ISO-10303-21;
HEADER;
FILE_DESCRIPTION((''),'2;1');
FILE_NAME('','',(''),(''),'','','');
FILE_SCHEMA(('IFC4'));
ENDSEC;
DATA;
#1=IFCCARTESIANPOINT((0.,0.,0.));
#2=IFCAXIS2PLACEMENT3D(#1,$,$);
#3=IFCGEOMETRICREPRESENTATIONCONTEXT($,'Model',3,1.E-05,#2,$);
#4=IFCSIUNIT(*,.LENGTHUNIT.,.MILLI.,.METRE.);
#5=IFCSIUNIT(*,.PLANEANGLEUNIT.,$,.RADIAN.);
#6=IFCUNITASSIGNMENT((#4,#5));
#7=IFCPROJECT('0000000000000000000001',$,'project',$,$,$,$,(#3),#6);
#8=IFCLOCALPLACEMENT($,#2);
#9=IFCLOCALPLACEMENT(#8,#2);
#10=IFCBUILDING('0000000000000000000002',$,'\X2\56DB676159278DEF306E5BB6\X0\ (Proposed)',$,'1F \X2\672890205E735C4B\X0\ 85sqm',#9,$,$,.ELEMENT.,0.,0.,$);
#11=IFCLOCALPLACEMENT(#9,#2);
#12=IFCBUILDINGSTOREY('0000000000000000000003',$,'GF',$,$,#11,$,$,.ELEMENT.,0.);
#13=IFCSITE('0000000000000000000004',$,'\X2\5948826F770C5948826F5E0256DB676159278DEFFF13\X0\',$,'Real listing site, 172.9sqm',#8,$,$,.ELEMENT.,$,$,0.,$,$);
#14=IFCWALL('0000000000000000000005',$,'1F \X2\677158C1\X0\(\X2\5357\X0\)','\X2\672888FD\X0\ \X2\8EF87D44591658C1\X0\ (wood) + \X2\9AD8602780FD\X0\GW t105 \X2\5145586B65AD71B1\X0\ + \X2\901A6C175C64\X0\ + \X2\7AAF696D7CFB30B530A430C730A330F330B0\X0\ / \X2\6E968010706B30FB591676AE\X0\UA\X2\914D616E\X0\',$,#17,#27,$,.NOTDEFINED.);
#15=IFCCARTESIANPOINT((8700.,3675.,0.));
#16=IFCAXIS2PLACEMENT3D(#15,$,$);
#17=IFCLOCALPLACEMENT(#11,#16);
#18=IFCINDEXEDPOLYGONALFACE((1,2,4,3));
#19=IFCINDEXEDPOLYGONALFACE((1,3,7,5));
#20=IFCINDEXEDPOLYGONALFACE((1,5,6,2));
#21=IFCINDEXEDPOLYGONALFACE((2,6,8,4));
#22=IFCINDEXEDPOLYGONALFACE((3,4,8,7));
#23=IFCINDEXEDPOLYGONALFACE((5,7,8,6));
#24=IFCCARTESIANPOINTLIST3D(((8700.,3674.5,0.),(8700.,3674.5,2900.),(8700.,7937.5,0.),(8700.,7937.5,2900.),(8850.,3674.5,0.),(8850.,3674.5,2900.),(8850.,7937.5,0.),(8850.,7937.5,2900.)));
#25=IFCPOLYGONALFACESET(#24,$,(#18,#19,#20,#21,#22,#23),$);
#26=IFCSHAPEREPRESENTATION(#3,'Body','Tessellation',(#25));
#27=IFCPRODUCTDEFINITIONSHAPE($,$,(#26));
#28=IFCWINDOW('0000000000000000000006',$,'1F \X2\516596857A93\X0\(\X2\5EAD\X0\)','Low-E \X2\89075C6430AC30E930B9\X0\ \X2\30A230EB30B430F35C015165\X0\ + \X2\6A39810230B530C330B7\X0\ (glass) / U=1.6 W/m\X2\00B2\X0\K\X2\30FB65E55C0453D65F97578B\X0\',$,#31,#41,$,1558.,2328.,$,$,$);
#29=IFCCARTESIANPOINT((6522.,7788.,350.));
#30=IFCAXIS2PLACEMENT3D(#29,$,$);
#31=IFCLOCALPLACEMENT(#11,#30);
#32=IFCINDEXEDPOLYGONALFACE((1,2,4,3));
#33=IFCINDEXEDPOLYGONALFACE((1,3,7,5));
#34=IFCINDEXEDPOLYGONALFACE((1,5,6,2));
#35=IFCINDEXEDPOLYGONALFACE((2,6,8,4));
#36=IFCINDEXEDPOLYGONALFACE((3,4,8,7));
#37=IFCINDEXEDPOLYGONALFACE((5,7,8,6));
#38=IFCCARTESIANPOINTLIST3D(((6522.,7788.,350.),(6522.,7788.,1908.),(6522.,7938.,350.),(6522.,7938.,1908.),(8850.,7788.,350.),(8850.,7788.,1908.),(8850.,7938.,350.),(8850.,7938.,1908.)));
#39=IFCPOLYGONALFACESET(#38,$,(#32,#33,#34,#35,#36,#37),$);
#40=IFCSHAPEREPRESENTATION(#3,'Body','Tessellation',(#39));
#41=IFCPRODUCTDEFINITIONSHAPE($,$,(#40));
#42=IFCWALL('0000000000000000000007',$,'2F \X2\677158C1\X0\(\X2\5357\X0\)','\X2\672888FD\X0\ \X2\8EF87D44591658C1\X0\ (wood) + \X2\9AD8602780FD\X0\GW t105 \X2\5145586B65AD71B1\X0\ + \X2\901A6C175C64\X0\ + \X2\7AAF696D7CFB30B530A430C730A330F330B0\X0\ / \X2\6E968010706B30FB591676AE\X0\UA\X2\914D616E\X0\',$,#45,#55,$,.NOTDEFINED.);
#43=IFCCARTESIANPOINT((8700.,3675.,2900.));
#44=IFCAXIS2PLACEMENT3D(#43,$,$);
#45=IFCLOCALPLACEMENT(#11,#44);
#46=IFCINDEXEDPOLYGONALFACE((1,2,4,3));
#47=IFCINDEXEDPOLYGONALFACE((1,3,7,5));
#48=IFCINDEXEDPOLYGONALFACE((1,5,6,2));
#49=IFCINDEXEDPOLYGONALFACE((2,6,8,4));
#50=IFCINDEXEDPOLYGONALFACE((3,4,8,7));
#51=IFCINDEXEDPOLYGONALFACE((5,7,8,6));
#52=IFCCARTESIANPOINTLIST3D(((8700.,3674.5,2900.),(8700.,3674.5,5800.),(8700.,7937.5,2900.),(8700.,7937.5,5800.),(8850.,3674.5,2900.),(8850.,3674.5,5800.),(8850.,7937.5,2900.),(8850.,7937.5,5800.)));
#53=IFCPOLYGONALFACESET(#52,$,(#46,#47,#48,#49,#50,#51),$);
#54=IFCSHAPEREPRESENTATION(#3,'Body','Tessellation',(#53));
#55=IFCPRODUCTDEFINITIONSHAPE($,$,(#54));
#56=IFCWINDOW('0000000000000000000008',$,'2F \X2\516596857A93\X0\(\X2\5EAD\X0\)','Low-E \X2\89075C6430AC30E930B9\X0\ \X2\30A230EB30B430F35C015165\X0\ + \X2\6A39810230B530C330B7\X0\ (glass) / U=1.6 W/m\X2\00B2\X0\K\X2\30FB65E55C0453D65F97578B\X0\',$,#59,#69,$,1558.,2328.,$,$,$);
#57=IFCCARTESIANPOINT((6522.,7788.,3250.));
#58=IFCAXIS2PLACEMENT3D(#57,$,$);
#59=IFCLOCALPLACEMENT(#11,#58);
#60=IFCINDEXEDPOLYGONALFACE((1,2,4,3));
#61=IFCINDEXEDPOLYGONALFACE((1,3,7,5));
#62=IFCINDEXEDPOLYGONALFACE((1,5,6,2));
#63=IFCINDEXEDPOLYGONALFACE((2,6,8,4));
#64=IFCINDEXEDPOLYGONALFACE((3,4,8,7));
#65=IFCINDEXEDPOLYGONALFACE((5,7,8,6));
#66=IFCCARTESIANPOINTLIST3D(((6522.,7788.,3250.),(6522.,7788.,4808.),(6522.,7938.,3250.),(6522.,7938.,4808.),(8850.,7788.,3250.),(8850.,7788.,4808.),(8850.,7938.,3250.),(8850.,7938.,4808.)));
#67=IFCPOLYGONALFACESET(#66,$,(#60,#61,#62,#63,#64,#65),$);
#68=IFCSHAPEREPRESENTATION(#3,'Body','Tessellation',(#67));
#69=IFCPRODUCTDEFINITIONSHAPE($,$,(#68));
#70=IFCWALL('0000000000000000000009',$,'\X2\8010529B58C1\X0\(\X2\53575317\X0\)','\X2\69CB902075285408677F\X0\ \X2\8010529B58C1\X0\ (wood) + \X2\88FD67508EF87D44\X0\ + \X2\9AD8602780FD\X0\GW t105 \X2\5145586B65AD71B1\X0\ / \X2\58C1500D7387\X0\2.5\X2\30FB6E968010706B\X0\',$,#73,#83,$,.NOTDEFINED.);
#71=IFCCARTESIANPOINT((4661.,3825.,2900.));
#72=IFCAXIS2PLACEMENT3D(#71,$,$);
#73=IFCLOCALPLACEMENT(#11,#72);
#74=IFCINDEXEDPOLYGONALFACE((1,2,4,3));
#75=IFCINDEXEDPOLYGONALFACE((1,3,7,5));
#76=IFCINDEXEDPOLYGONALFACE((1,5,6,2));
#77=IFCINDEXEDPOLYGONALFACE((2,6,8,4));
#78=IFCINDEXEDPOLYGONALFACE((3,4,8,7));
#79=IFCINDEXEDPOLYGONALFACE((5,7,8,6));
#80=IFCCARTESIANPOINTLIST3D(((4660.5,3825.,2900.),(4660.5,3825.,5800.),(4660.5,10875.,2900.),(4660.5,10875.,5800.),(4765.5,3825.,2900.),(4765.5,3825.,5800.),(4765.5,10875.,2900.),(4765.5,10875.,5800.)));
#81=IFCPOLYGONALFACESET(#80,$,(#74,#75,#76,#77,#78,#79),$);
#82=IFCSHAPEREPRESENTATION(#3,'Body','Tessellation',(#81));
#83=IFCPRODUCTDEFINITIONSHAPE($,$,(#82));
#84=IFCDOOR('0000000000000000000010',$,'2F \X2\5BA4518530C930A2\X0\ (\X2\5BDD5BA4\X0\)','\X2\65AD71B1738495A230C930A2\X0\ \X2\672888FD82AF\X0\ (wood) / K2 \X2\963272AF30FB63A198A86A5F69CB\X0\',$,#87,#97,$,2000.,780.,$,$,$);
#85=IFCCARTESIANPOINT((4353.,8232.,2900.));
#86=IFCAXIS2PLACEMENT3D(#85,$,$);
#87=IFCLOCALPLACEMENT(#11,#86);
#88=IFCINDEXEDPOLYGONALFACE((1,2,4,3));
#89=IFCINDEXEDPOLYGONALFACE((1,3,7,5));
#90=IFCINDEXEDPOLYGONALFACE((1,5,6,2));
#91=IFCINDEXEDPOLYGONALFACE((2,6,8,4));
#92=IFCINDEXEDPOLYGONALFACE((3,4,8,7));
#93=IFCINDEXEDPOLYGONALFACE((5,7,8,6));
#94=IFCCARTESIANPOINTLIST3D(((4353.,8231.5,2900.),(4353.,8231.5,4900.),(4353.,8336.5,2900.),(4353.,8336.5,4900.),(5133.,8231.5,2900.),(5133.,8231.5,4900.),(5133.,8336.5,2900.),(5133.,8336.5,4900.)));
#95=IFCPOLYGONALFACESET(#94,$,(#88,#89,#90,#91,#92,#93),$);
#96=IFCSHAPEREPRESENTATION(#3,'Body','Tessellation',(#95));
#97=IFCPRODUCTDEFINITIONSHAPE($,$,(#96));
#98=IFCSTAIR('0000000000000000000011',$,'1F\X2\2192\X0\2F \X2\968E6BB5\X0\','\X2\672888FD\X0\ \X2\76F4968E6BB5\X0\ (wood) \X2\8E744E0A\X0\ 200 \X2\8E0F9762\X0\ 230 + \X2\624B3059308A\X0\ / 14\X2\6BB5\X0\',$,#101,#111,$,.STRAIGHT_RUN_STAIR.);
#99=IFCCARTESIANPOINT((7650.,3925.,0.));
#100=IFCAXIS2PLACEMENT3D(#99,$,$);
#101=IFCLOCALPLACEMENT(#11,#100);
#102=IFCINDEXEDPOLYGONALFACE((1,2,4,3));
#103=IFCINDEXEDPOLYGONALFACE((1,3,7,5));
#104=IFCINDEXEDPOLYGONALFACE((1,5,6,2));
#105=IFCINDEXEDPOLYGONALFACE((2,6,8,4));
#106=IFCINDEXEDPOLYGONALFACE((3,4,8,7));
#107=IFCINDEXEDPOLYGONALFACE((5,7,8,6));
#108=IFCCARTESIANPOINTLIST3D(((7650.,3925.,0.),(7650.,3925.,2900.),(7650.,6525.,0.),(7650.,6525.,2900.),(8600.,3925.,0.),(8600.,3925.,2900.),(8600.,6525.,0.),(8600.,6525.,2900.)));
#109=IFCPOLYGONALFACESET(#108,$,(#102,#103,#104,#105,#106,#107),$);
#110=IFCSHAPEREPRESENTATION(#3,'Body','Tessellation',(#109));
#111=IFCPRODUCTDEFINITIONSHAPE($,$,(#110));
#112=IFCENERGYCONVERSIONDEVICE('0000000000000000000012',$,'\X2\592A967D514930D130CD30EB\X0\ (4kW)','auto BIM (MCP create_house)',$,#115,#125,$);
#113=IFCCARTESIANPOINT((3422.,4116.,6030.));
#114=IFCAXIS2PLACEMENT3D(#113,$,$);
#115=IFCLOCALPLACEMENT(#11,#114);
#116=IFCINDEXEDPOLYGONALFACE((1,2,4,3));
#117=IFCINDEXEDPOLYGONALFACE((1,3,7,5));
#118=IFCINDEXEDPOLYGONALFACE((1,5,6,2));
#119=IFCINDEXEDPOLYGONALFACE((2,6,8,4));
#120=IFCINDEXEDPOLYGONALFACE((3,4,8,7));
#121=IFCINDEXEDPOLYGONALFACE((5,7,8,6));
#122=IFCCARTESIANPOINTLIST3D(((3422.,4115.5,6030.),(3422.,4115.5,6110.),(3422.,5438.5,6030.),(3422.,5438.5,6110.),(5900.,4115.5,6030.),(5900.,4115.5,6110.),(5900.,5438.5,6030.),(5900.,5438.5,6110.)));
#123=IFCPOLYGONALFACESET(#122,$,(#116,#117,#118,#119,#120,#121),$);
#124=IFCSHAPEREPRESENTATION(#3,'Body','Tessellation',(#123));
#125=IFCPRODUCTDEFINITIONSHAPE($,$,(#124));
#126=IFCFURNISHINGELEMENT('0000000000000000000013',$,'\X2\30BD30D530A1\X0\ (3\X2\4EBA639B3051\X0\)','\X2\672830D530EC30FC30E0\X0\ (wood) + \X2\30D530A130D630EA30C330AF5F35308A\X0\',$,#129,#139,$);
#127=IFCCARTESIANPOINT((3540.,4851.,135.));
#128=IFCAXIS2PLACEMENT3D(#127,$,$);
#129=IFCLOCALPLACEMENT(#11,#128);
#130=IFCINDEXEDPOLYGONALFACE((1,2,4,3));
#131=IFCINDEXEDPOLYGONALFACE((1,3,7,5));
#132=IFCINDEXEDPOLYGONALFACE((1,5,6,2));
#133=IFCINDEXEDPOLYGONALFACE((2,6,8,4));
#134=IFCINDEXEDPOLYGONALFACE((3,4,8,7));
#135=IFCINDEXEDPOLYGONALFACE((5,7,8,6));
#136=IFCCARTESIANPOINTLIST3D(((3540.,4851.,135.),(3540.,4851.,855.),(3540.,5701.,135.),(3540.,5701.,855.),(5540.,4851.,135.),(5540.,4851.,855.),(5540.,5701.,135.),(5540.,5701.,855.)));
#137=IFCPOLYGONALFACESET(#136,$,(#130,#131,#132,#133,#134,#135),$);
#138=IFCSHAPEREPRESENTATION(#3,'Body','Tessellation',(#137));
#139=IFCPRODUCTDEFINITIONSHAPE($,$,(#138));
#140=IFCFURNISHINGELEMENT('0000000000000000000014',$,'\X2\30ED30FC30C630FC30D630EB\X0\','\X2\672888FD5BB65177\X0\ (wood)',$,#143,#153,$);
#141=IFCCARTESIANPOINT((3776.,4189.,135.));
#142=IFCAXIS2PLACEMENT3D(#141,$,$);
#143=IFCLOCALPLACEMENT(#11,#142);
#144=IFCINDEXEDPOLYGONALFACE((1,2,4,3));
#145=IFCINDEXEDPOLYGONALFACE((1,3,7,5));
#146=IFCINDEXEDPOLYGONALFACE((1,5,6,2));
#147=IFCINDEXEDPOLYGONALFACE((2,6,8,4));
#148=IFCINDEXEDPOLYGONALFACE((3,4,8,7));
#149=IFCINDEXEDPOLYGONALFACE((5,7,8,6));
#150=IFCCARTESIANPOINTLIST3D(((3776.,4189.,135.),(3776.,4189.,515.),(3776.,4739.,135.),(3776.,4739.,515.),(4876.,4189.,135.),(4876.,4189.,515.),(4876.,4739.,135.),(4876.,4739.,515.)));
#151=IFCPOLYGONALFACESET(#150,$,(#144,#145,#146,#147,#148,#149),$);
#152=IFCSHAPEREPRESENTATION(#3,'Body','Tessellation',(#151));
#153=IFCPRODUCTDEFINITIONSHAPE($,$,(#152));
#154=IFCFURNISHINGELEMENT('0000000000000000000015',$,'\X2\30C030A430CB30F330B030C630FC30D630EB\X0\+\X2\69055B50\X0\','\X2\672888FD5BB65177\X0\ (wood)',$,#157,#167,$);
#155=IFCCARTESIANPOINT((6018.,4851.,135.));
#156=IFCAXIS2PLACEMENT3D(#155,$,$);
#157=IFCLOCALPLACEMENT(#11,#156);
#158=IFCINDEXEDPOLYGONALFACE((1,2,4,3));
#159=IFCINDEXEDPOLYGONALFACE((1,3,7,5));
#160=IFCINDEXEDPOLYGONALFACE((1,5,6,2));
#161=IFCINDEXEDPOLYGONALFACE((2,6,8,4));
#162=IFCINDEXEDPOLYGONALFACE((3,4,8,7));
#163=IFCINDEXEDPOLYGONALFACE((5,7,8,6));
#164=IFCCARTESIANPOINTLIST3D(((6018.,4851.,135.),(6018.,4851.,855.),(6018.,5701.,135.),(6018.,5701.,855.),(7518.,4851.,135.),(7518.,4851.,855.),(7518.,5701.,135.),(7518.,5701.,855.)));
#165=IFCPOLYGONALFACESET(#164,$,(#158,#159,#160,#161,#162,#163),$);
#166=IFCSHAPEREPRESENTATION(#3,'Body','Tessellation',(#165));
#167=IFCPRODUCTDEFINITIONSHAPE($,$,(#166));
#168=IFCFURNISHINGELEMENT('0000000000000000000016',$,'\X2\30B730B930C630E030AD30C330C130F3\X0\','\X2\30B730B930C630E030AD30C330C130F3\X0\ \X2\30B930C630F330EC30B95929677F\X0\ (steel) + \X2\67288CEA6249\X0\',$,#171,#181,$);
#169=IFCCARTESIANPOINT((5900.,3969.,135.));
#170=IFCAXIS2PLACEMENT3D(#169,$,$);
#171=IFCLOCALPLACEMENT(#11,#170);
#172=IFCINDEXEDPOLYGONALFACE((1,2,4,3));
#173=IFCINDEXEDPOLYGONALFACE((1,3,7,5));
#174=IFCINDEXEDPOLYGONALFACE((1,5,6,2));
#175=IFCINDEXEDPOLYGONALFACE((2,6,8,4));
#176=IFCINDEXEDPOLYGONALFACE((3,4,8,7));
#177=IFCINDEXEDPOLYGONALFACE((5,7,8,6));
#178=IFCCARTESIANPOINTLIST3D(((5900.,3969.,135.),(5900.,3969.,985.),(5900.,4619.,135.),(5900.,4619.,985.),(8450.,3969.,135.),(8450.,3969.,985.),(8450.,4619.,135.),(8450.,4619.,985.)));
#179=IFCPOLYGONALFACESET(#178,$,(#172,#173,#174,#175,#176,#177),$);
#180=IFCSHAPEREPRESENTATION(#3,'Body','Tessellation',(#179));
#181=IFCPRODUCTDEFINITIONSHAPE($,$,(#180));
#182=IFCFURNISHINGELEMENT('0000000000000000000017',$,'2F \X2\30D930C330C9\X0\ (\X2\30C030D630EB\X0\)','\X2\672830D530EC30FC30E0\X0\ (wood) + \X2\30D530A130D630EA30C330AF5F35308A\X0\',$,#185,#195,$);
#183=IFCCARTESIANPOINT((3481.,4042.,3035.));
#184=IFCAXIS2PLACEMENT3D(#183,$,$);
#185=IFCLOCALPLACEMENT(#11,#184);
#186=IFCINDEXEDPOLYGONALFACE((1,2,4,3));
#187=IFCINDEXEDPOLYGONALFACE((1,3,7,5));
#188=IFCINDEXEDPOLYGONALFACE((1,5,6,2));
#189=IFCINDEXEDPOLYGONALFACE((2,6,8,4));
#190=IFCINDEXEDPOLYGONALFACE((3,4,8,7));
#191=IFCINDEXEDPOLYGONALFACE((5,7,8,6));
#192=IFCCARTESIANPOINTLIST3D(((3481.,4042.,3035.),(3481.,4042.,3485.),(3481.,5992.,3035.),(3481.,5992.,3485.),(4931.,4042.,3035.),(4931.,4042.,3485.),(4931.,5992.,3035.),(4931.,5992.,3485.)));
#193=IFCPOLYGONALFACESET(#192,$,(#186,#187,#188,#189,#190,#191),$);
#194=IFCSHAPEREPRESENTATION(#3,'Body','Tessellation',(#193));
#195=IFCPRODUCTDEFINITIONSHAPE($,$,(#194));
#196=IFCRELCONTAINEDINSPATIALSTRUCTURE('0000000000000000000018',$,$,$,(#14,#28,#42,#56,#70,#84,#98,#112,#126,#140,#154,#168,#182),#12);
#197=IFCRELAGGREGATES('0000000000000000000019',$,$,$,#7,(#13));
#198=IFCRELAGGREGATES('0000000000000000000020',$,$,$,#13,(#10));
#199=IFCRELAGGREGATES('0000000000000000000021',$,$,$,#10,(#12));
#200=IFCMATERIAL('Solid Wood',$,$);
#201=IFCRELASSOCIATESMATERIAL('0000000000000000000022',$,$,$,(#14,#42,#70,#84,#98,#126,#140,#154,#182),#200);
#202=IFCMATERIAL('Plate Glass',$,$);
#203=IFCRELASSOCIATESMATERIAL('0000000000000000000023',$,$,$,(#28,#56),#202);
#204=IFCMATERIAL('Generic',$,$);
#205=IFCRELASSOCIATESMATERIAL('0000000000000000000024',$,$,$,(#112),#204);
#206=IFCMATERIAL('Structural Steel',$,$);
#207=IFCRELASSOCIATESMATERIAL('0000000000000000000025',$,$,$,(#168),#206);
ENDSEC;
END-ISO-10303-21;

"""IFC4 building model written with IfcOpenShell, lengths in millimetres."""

from ifc_helpers import new_model, si_unit, frame, frame_2d, origin, place, context, project, spatial, rectangle, extrude, material, element, fill, save


model = new_model("IFC4")

# Units and contexts
model_context = context("Model", 3, precision=1e-05, world=origin())
ifc_project = project(units=[si_unit("LENGTHUNIT", "METRE", prefix="MILLI"), si_unit("PLANEANGLEUNIT", "RADIAN")], contexts=[model_context])

# Site, building, storey
site_placement = place(None, origin())
site = spatial("IfcSite", under=ifc_project, at=site_placement, Name="奈良県奈良市四条大路３", ObjectType="Real listing site, 172.9sqm", CompositionType="ELEMENT", RefElevation=0.0)
building_placement = place(site_placement, origin())
building = spatial("IfcBuilding", under=site, at=building_placement, Name="四条大路の家 (Proposed)", ObjectType="1F 木造平屋 85sqm", CompositionType="ELEMENT", ElevationOfRefHeight=0.0, ElevationOfTerrain=0.0)
storey_placement = place(building_placement, origin())
storey = spatial("IfcBuildingStorey", under=building, at=storey_placement, Name="GF", CompositionType="ELEMENT", Elevation=0.0)

# Wall, opening, window
ifc_material_1 = material(Name="Solid Wood")
wall_1_placement = place(storey_placement, frame((8700.0, 3675.0, 0.0)))
wall_1 = element("IfcWall", 1, at=wall_1_placement, inside=storey, material=ifc_material_1, Name="1F 東壁(南)", Description="木製 軸組外壁 (wood) + 高性能GW t105 充填断熱 + 通気層 + 窯業系サイディング / 準耐火・外皮UA配慮", PredefinedType="NOTDEFINED", context=model_context, shape_type="SweptSolid", body=[
    extrude(rectangle(XDim=150.0, YDim=4263.0, at=frame_2d((75.0, 2131.0))), frame((8700.0, 3675.0, 0.0)), (0.0, 0.0, 1.0), 2900.0),
])
opening_1_placement = place(storey_placement, frame((6522.0, 7788.0, 350.0)))
opening_1 = element("IfcOpeningElement", 2, at=opening_1_placement, cuts=wall_1, PredefinedType="NOTDEFINED", context=model_context, shape_type="SweptSolid", body=[
    extrude(rectangle(XDim=2328.0, YDim=150.0, at=frame_2d((1164.0, 75.0))), frame((6522.0, 7788.0, 350.0)), (0.0, 0.0, 1.0), 1558.0),
])
ifc_material_2 = material(Name="Plate Glass")
window_1_placement = place(storey_placement, frame((6522.0, 7788.0, 350.0)))
window_1 = element("IfcWindow", 3, at=window_1_placement, inside=storey, material=ifc_material_2, Name="1F 入隅窓(庭)", Description="Low-E 複層ガラス アルゴン封入 + 樹脂サッシ (glass) / U=1.6 W/m²K・日射取得型", OverallHeight=1558.0, OverallWidth=2328.0, context=model_context, shape_type="SweptSolid", body=[
    extrude(rectangle(XDim=2328.0, YDim=150.0, at=frame_2d((1164.0, 75.0))), frame((6522.0, 7788.0, 350.0)), (0.0, 0.0, 1.0), 1558.0),
])
fill(opening_1, window_1)

# Wall, opening, window
wall_2_placement = place(storey_placement, frame((8700.0, 3675.0, 2900.0)))
wall_2 = element("IfcWall", 4, at=wall_2_placement, inside=storey, material=ifc_material_1, Name="2F 東壁(南)", Description="木製 軸組外壁 (wood) + 高性能GW t105 充填断熱 + 通気層 + 窯業系サイディング / 準耐火・外皮UA配慮", PredefinedType="NOTDEFINED", context=model_context, shape_type="SweptSolid", body=[
    extrude(rectangle(XDim=150.0, YDim=4263.0, at=frame_2d((75.0, 2131.0))), frame((8700.0, 3675.0, 2900.0)), (0.0, 0.0, 1.0), 2900.0),
])
opening_2_placement = place(storey_placement, frame((6522.0, 7788.0, 3250.0)))
opening_2 = element("IfcOpeningElement", 5, at=opening_2_placement, cuts=wall_2, PredefinedType="NOTDEFINED", context=model_context, shape_type="SweptSolid", body=[
    extrude(rectangle(XDim=2328.0, YDim=150.0, at=frame_2d((1164.0, 75.0))), frame((6522.0, 7788.0, 3250.0)), (0.0, 0.0, 1.0), 1558.0),
])
window_2_placement = place(storey_placement, frame((6522.0, 7788.0, 3250.0)))
window_2 = element("IfcWindow", 6, at=window_2_placement, inside=storey, material=ifc_material_2, Name="2F 入隅窓(庭)", Description="Low-E 複層ガラス アルゴン封入 + 樹脂サッシ (glass) / U=1.6 W/m²K・日射取得型", OverallHeight=1558.0, OverallWidth=2328.0, context=model_context, shape_type="SweptSolid", body=[
    extrude(rectangle(XDim=2328.0, YDim=150.0, at=frame_2d((1164.0, 75.0))), frame((6522.0, 7788.0, 3250.0)), (0.0, 0.0, 1.0), 1558.0),
])
fill(opening_2, window_2)

# Wall, opening, door
wall_3_placement = place(storey_placement, frame((4661.0, 3825.0, 2900.0)))
wall_3 = element("IfcWall", 7, at=wall_3_placement, inside=storey, material=ifc_material_1, Name="耐力壁(南北)", Description="構造用合板 耐力壁 (wood) + 製材軸組 + 高性能GW t105 充填断熱 / 壁倍率2.5・準耐火", PredefinedType="NOTDEFINED", context=model_context, shape_type="SweptSolid", body=[
    extrude(rectangle(XDim=105.0, YDim=7050.0, at=frame_2d((52.0, 3525.0))), frame((4661.0, 3825.0, 2900.0)), (0.0, 0.0, 1.0), 2900.0),
])
opening_3_placement = place(storey_placement, frame((4353.0, 8232.0, 2900.0)))
opening_3 = element("IfcOpeningElement", 8, at=opening_3_placement, cuts=wall_3, PredefinedType="NOTDEFINED", context=model_context, shape_type="SweptSolid", body=[
    extrude(rectangle(XDim=780.0, YDim=105.0, at=frame_2d((390.0, 52.0))), frame((4353.0, 8232.0, 2900.0)), (0.0, 0.0, 1.0), 2000.0),
])
door_1_placement = place(storey_placement, frame((4353.0, 8232.0, 2900.0)))
door_1 = element("IfcDoor", 9, at=door_1_placement, inside=storey, material=ifc_material_1, Name="2F 室内ドア (寝室)", Description="断熱玄関ドア 木製芯 (wood) / K2 防犯・採風機構", OverallHeight=2000.0, OverallWidth=780.0, context=model_context, shape_type="SweptSolid", body=[
    extrude(rectangle(XDim=780.0, YDim=105.0, at=frame_2d((390.0, 52.0))), frame((4353.0, 8232.0, 2900.0)), (0.0, 0.0, 1.0), 2000.0),
])
fill(opening_3, door_1)

# Stair
stair_placement = place(storey_placement, frame((7650.0, 3925.0, 0.0)))
element("IfcStair", 10, at=stair_placement, inside=storey, material=ifc_material_1, Name="1F→2F 階段", Description="木製 直階段 (wood) 蹴上 200 踏面 230 + 手すり / 14段", PredefinedType="STRAIGHT_RUN_STAIR", context=model_context, shape_type="SweptSolid", body=[
    extrude(rectangle(XDim=950.0, YDim=2600.0, at=frame_2d((475.0, 1300.0))), frame((7650.0, 3925.0, 0.0)), (0.0, 0.0, 1.0), 2900.0),
])

# Energy conversion device
ifc_material_3 = material(Name="Generic")
energy_conversion_device_placement = place(storey_placement, frame((3422.0, 4116.0, 6030.0)))
element("IfcEnergyConversionDevice", 11, at=energy_conversion_device_placement, inside=storey, material=ifc_material_3, Name="太陽光パネル (4kW)", Description="auto BIM (MCP create_house)", context=model_context, shape_type="SweptSolid", body=[
    extrude(rectangle(XDim=2478.0, YDim=1323.0, at=frame_2d((1239.0, 661.0))), frame((3422.0, 4116.0, 6030.0)), (0.0, 0.0, 1.0), 80.0),
])

# Furnishing elements
furnishing_1_placement = place(storey_placement, frame((3540.0, 4851.0, 135.0)))
element("IfcFurnishingElement", 12, at=furnishing_1_placement, inside=storey, material=ifc_material_1, Name="ソファ (3人掛け)", Description="木フレーム (wood) + ファブリック張り", context=model_context, shape_type="SweptSolid", body=[
    extrude(rectangle(XDim=2000.0, YDim=850.0, at=frame_2d((1000.0, 425.0))), frame((3540.0, 4851.0, 135.0)), (0.0, 0.0, 1.0), 720.0),
])
furnishing_2_placement = place(storey_placement, frame((3776.0, 4189.0, 135.0)))
element("IfcFurnishingElement", 13, at=furnishing_2_placement, inside=storey, material=ifc_material_1, Name="ローテーブル", Description="木製家具 (wood)", context=model_context, shape_type="SweptSolid", body=[
    extrude(rectangle(XDim=1100.0, YDim=550.0, at=frame_2d((550.0, 275.0))), frame((3776.0, 4189.0, 135.0)), (0.0, 0.0, 1.0), 380.0),
])
furnishing_3_placement = place(storey_placement, frame((6018.0, 4851.0, 135.0)))
element("IfcFurnishingElement", 14, at=furnishing_3_placement, inside=storey, material=ifc_material_1, Name="ダイニングテーブル+椅子", Description="木製家具 (wood)", context=model_context, shape_type="SweptSolid", body=[
    extrude(rectangle(XDim=1500.0, YDim=850.0, at=frame_2d((750.0, 425.0))), frame((6018.0, 4851.0, 135.0)), (0.0, 0.0, 1.0), 720.0),
])
ifc_material_4 = material(Name="Structural Steel")
furnishing_4_placement = place(storey_placement, frame((5900.0, 3969.0, 135.0)))
element("IfcFurnishingElement", 15, at=furnishing_4_placement, inside=storey, material=ifc_material_4, Name="システムキッチン", Description="システムキッチン ステンレス天板 (steel) + 木質扉", context=model_context, shape_type="SweptSolid", body=[
    extrude(rectangle(XDim=2550.0, YDim=650.0, at=frame_2d((1275.0, 325.0))), frame((5900.0, 3969.0, 135.0)), (0.0, 0.0, 1.0), 850.0),
])
furnishing_5_placement = place(storey_placement, frame((3481.0, 4042.0, 3035.0)))
element("IfcFurnishingElement", 16, at=furnishing_5_placement, inside=storey, material=ifc_material_1, Name="2F ベッド (ダブル)", Description="木フレーム (wood) + ファブリック張り", context=model_context, shape_type="SweptSolid", body=[
    extrude(rectangle(XDim=1450.0, YDim=1950.0, at=frame_2d((725.0, 975.0))), frame((3481.0, 4042.0, 3035.0)), (0.0, 0.0, 1.0), 450.0),
])

save(model, "model.ifc")
